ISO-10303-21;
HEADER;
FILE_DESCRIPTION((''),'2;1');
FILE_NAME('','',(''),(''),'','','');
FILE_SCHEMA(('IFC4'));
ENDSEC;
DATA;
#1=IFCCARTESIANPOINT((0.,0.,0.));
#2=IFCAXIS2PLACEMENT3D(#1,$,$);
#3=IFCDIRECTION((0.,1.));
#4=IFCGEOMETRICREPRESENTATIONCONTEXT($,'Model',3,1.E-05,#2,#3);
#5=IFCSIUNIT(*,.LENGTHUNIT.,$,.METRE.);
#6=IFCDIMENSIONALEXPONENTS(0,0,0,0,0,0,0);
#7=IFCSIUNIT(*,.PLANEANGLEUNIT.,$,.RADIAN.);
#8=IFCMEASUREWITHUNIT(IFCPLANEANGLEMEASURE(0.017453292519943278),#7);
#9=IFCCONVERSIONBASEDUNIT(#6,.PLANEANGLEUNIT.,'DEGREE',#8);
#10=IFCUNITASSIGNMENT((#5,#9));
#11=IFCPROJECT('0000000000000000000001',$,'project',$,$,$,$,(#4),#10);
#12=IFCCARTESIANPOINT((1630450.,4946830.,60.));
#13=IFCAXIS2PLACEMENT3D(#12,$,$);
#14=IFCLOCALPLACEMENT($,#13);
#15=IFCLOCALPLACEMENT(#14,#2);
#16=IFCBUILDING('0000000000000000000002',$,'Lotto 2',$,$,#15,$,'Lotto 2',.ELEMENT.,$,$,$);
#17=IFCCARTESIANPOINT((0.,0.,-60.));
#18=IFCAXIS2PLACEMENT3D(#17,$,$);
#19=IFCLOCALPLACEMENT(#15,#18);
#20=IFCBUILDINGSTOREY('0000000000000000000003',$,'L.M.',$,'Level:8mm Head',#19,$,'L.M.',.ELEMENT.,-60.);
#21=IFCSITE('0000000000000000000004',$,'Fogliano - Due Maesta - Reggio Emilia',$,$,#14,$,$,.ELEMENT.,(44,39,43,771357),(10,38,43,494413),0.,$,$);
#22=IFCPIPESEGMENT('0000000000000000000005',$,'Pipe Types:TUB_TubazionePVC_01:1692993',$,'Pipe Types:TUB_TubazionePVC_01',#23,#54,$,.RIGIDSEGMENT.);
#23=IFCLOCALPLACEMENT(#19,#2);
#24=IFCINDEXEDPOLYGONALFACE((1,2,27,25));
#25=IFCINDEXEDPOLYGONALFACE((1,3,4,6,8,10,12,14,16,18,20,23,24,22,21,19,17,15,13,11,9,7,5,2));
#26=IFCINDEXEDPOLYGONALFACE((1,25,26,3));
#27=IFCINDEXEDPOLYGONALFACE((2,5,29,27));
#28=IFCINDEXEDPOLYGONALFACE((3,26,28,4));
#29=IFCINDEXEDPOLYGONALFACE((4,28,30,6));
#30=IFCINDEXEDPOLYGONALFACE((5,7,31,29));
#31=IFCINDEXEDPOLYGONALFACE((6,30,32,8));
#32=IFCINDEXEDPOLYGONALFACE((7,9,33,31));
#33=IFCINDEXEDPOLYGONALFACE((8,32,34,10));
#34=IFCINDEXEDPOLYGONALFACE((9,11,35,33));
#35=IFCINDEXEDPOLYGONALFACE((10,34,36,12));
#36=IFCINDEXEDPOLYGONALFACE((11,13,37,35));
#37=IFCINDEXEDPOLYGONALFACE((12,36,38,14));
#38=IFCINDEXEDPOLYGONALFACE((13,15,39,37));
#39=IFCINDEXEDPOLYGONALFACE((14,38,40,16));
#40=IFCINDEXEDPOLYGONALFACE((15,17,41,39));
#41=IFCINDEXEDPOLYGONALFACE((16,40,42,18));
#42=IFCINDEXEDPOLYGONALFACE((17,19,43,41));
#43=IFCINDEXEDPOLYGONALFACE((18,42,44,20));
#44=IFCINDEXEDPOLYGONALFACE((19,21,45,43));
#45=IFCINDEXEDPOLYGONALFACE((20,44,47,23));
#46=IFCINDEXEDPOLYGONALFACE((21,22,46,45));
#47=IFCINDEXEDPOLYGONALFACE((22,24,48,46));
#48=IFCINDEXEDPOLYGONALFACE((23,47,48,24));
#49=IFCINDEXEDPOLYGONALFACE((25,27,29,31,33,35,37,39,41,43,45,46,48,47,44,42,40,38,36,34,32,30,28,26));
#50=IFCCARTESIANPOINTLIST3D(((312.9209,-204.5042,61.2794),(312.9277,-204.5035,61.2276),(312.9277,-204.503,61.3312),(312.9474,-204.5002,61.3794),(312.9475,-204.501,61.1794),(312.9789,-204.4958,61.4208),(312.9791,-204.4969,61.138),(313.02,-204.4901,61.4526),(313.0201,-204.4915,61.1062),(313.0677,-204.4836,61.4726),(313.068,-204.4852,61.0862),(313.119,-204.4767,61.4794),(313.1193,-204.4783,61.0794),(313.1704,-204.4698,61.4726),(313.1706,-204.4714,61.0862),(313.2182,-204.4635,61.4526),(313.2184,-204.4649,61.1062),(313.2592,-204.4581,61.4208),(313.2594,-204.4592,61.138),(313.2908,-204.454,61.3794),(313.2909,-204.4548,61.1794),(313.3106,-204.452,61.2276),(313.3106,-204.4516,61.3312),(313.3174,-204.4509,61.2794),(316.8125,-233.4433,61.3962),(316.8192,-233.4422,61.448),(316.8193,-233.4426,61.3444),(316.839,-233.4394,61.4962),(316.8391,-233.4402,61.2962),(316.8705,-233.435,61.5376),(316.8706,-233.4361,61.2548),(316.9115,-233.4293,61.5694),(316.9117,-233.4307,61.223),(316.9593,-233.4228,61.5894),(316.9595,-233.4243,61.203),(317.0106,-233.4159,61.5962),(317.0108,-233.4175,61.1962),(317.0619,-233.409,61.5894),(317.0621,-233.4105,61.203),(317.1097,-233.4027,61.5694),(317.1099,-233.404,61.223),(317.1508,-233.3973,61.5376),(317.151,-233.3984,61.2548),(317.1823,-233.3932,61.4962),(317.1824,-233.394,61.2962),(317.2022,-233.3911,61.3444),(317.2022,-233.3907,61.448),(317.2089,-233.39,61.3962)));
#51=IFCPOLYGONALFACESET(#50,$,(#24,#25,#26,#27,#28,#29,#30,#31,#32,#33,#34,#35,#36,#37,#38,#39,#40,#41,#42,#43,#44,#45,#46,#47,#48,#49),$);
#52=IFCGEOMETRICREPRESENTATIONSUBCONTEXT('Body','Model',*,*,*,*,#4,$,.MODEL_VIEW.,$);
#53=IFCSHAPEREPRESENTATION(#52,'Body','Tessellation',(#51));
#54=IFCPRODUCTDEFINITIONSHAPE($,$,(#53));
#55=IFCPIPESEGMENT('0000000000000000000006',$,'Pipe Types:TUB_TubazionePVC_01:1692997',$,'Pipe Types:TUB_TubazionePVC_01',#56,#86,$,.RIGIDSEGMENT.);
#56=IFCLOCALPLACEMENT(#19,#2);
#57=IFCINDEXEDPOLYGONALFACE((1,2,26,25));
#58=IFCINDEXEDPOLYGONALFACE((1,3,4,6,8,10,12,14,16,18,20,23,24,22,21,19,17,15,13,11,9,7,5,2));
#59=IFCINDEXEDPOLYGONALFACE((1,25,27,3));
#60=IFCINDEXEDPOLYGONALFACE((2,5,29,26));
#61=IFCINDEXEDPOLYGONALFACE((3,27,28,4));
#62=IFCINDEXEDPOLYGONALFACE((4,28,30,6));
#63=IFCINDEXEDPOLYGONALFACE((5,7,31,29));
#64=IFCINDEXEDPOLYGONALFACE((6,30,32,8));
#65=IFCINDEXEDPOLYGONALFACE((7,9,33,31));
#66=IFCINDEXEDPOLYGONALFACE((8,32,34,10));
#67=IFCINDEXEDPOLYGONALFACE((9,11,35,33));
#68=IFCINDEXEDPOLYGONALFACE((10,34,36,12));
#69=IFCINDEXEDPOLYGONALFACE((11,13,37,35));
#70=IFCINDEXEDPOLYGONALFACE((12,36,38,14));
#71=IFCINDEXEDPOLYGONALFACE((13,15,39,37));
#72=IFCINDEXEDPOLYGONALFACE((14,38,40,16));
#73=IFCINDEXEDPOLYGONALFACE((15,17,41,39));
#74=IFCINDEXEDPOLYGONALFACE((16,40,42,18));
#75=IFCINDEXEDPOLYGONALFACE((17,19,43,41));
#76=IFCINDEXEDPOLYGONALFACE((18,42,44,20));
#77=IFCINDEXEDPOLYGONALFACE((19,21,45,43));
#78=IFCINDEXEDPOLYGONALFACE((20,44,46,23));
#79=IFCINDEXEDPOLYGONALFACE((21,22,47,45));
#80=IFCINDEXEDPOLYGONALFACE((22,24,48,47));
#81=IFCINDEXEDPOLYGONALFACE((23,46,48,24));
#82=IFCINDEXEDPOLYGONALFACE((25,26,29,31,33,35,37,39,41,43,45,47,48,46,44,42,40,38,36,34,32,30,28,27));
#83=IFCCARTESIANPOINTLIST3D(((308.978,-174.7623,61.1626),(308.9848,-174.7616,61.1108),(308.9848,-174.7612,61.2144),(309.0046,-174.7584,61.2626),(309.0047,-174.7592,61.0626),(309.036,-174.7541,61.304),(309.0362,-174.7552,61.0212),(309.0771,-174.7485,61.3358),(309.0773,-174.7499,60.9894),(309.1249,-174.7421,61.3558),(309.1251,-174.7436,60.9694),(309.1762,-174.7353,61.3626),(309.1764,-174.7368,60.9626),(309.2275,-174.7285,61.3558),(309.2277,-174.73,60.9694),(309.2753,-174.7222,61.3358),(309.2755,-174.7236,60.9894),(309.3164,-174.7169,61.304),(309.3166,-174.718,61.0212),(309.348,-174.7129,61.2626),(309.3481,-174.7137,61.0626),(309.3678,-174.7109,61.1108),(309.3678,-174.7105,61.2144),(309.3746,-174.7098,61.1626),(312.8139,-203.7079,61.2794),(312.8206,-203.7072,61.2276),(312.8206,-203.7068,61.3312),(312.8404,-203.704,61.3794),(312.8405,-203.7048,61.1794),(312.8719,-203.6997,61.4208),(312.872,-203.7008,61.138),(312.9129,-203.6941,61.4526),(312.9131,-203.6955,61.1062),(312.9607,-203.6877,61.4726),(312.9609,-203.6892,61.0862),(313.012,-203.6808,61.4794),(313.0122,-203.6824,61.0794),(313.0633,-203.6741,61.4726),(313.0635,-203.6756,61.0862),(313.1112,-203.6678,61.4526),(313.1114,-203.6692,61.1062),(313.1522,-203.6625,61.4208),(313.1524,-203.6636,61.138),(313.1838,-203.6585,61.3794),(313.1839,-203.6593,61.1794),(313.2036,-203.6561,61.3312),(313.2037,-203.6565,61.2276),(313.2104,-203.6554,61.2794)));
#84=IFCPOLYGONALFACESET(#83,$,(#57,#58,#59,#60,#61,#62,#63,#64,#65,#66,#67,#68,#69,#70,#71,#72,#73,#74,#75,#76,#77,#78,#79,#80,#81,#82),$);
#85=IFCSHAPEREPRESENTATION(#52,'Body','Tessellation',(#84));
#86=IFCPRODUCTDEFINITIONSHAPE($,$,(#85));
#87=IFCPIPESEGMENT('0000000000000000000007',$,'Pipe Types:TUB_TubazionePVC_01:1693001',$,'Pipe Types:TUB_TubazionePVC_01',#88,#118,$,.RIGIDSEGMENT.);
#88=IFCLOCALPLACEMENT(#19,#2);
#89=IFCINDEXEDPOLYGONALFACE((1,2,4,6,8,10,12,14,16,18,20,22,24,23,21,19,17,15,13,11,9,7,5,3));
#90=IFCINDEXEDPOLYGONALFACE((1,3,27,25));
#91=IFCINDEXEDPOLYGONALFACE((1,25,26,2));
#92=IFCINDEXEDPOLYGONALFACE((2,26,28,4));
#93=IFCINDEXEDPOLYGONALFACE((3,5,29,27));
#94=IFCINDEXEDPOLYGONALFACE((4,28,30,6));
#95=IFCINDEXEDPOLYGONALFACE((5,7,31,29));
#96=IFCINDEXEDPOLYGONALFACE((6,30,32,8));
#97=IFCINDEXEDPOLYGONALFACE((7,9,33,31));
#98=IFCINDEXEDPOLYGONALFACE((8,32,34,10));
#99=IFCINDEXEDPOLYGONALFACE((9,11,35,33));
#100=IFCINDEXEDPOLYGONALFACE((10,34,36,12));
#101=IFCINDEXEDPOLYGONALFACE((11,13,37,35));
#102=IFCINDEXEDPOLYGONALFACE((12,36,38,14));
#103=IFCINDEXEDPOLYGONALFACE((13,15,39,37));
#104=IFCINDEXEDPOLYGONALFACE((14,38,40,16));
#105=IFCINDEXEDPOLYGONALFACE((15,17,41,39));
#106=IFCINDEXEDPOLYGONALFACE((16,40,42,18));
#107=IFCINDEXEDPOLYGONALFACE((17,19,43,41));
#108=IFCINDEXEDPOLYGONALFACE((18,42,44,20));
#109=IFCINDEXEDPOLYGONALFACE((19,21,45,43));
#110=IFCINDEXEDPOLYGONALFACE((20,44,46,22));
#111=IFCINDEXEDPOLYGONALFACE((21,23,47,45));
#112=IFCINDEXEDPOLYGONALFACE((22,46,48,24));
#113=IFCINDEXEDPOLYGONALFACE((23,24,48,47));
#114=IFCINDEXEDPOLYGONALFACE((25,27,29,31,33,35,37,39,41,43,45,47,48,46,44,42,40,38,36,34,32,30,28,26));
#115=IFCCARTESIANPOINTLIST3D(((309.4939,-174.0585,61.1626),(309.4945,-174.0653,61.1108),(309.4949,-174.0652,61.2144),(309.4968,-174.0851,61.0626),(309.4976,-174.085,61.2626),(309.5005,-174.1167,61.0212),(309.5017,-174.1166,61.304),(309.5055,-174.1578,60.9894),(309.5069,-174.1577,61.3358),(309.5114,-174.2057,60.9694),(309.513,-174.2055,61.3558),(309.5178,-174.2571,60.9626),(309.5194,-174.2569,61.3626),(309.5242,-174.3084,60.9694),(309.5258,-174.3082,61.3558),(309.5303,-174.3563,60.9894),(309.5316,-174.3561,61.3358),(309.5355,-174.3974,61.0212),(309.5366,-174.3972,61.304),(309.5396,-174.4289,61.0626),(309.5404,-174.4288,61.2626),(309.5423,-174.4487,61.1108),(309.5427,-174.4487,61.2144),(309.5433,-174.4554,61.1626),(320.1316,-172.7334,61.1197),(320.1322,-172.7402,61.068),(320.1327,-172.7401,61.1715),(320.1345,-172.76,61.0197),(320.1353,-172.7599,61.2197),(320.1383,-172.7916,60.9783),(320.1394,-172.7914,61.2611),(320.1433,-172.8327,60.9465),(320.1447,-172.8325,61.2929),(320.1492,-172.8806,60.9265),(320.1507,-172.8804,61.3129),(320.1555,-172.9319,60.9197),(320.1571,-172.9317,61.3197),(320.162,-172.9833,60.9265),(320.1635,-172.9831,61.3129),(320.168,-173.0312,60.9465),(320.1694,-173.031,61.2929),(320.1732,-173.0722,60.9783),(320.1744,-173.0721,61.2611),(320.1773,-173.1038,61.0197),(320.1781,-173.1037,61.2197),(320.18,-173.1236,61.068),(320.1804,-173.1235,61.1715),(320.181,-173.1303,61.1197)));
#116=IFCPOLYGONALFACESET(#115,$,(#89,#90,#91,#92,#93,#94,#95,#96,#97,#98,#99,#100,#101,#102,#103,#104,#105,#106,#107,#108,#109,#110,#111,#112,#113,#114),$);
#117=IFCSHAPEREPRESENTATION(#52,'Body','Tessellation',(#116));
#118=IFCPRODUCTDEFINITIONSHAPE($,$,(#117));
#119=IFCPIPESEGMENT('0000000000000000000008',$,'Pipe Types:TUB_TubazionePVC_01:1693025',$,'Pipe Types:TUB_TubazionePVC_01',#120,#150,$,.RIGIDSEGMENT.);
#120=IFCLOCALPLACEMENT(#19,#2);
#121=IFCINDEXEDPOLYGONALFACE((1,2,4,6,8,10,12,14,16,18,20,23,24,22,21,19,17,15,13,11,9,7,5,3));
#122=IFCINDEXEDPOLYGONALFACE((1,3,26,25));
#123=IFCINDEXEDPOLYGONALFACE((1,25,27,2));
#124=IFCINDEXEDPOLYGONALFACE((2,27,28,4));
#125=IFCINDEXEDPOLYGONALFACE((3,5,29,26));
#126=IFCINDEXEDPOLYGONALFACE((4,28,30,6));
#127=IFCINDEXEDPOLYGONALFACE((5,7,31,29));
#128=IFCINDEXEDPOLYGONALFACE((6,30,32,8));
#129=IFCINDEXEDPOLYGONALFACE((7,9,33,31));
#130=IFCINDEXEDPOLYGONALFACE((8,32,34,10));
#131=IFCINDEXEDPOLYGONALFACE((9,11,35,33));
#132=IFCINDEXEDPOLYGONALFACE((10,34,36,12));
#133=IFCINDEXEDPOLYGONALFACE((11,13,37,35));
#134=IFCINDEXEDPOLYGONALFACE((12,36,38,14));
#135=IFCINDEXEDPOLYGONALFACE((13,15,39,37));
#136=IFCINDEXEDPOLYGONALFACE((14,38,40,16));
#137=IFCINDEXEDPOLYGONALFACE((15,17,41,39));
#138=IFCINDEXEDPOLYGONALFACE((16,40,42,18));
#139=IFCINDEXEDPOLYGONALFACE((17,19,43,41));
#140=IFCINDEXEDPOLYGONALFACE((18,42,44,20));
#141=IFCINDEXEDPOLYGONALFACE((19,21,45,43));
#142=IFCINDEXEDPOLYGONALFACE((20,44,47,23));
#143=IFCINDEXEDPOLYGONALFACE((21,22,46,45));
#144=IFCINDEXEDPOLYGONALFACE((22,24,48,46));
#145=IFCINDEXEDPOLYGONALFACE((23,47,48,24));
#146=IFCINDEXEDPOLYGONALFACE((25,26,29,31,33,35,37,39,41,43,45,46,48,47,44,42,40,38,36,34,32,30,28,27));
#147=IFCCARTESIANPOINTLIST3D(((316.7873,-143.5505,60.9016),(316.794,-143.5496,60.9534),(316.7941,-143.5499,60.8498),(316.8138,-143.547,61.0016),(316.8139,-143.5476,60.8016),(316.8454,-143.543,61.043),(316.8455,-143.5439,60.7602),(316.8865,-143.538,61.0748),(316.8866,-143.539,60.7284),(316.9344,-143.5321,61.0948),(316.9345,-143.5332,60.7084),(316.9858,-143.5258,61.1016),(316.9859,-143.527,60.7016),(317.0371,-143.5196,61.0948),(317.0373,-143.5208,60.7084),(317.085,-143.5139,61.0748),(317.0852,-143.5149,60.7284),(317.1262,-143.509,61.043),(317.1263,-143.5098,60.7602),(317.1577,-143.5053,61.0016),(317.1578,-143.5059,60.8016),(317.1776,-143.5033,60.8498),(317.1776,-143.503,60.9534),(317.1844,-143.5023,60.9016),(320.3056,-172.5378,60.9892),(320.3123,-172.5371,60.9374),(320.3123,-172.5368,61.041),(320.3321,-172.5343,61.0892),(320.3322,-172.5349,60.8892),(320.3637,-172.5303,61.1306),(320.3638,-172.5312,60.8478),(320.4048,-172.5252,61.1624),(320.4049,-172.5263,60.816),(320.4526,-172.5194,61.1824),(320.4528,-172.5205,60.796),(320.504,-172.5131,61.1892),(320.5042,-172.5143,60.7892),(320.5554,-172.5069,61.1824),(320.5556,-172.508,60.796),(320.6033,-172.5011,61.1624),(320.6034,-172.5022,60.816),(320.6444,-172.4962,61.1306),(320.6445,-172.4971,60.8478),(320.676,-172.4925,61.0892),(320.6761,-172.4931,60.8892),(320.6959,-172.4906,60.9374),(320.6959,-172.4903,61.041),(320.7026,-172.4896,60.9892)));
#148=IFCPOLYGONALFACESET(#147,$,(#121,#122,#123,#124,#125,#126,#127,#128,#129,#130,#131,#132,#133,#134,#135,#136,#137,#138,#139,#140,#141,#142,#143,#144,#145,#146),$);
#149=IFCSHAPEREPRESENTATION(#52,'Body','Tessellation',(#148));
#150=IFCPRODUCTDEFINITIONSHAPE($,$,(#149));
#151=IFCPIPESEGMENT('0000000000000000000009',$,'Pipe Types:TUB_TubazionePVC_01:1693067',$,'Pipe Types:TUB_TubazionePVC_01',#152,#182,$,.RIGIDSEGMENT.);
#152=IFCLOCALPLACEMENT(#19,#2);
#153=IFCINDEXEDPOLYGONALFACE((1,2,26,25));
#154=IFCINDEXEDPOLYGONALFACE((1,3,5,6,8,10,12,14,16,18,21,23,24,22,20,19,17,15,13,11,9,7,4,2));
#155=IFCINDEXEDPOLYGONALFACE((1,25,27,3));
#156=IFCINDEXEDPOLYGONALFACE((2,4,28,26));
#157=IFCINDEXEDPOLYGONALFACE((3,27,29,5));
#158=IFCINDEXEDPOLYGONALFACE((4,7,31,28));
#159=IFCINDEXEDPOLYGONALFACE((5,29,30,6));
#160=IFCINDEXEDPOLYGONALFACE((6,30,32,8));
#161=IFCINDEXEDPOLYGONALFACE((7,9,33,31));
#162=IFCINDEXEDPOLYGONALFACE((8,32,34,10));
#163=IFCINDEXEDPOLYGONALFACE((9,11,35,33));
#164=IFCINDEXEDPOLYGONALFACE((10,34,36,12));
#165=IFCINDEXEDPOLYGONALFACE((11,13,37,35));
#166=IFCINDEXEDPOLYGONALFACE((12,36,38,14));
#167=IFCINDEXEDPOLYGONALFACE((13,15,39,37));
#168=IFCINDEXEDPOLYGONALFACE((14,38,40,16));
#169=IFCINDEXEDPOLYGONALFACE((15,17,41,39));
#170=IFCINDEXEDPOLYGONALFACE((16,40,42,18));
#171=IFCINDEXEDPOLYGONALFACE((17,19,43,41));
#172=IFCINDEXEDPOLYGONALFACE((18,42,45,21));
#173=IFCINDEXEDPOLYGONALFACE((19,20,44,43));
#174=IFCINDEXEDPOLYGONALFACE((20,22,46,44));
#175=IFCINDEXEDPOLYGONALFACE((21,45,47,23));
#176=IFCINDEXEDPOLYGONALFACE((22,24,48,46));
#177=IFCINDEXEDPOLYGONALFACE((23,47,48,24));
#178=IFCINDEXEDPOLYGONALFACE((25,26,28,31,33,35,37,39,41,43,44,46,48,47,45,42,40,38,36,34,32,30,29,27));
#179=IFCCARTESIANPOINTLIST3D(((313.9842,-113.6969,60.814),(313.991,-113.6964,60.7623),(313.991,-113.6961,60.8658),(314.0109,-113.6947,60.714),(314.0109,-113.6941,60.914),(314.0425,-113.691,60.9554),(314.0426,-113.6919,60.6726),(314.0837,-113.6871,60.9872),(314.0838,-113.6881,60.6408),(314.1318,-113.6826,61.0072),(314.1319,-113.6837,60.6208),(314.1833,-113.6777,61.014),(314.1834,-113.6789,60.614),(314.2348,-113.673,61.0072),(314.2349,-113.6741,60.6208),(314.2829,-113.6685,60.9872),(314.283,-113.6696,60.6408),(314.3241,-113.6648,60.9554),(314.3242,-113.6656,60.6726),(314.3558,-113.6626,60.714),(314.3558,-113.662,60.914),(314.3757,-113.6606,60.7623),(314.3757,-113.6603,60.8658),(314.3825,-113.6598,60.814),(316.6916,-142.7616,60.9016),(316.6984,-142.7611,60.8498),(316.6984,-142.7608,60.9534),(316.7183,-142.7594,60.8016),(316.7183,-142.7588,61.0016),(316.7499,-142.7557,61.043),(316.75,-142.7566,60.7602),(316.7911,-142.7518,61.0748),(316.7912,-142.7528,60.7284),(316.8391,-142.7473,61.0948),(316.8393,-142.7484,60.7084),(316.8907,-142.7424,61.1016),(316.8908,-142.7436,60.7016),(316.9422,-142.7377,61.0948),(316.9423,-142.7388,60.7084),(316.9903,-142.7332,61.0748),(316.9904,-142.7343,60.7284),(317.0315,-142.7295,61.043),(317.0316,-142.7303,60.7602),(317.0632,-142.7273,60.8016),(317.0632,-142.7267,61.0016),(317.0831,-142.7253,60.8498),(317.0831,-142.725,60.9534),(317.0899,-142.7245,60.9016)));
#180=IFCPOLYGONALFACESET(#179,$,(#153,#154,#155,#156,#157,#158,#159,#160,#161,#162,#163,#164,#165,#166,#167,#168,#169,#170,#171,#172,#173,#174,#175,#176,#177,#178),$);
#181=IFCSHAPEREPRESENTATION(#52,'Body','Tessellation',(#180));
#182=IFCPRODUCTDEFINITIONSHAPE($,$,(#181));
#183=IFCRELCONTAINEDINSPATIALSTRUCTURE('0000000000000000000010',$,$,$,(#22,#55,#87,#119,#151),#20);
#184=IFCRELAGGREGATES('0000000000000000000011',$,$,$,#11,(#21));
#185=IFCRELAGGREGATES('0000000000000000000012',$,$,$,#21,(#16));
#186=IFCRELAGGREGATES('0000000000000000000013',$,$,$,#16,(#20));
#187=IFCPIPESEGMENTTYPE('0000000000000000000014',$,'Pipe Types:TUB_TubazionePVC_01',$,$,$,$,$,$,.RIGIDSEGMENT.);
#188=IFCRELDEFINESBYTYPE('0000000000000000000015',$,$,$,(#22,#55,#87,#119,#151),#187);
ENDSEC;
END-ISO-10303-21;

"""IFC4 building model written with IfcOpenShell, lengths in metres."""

from ifc_helpers import new_model, entity, si_unit, converted_unit, direction, frame, origin, place, context, subcontext, project, spatial, arc, indexed_curve, outline, extrude, type_object, element, save


model = new_model("IFC4")

# Units and contexts
model_context = context("Model", 3, precision=1e-05, world=origin(), true_north=direction((0.0, 1.0)))
body_context = subcontext(model_context, "Body", "Model", "MODEL_VIEW")
ifc_project = project(units=[si_unit("LENGTHUNIT", "METRE"), converted_unit("PLANEANGLEUNIT", "DEGREE", entity("IfcPlaneAngleMeasure", 0.017453292519943278), si_unit("PLANEANGLEUNIT", "RADIAN"), dimensions=[0, 0, 0, 0, 0, 0, 0])], contexts=[model_context])

# Site, building, storey
site_placement = place(None, frame((1630450.0, 4946830.0, 60.0)))
site = spatial("IfcSite", under=ifc_project, at=site_placement, Name="Fogliano - Due Maesta - Reggio Emilia", CompositionType="ELEMENT", RefLatitude=(44, 39, 43, 771357), RefLongitude=(10, 38, 43, 494413), RefElevation=0.0)
building_placement = place(site_placement, origin())
building = spatial("IfcBuilding", under=site, at=building_placement, Name="Lotto 2", LongName="Lotto 2", CompositionType="ELEMENT")
storey_placement = place(building_placement, frame((0.0, 0.0, -60.0)))
storey = spatial("IfcBuildingStorey", under=building, at=storey_placement, Name="L.M.", ObjectType="Level:8mm Head", LongName="L.M.", CompositionType="ELEMENT", Elevation=-60.0)

# Pipe segments
pipe_segment_type = type_object("IfcPipeSegmentType", Name="Pipe Types:TUB_TubazionePVC_01", PredefinedType="RIGIDSEGMENT")
pipe_segment_1_placement = place(storey_placement, origin())
element("IfcPipeSegment", 1, at=pipe_segment_1_placement, inside=storey, type_object=pipe_segment_type, Name="Pipe Types:TUB_TubazionePVC_01:1692993", ObjectType="Pipe Types:TUB_TubazionePVC_01", PredefinedType="RIGIDSEGMENT", context=body_context, shape_type="SweptSolid", body=[
    extrude(outline(indexed_curve([(0.2, 0.0), (0.1414, 0.1414), (0.0, 0.2), (-0.1414, 0.1414), (-0.2, 0.0), (-0.1414, -0.1414), (0.0, -0.2), (0.1414, -0.1414)], segments=[arc(1, 2, 3), arc(3, 4, 5), arc(5, 6, 7), arc(7, 8, 1)], self_intersect=False)), frame((317.0107, -233.4167, 61.3962), z_axis=(-0.133273, 0.991071, -0.004), x_axis=(0.991079, 0.133275, 0.0)), (0.0, 0.0, 1.0), 29.1999),
])
pipe_segment_2_placement = place(storey_placement, origin())
element("IfcPipeSegment", 2, at=pipe_segment_2_placement, inside=storey, type_object=pipe_segment_type, Name="Pipe Types:TUB_TubazionePVC_01:1692997", ObjectType="Pipe Types:TUB_TubazionePVC_01", PredefinedType="RIGIDSEGMENT", context=body_context, shape_type="SweptSolid", body=[
    extrude(outline(indexed_curve([(0.2, 0.0), (0.1414, 0.1414), (0.0, 0.2), (-0.1414, 0.1414), (-0.2, 0.0), (-0.1414, -0.1414), (0.0, -0.2), (0.1414, -0.1414)], segments=[arc(1, 2, 3), arc(3, 4, 5), arc(5, 6, 7), arc(7, 8, 1)], self_intersect=False)), frame((309.1763, -174.736, 61.1626), z_axis=(0.131369, -0.991326, 0.004), x_axis=(0.991333, 0.13137, 0.0)), (0.0, 0.0, 1.0), 29.1989),
])
pipe_segment_3_placement = place(storey_placement, origin())
element("IfcPipeSegment", 3, at=pipe_segment_3_placement, inside=storey, type_object=pipe_segment_type, Name="Pipe Types:TUB_TubazionePVC_01:1693001", ObjectType="Pipe Types:TUB_TubazionePVC_01", PredefinedType="RIGIDSEGMENT", context=body_context, shape_type="SweptSolid", body=[
    extrude(outline(indexed_curve([(0.2, 0.0), (0.1414, 0.1414), (0.0, 0.2), (-0.1414, 0.1414), (-0.2, 0.0), (-0.1414, -0.1414), (0.0, -0.2), (0.1414, -0.1414)], segments=[arc(1, 2, 3), arc(3, 4, 5), arc(5, 6, 7), arc(7, 8, 1)], self_intersect=False)), frame((320.1563, -172.9318, 61.1197), z_axis=(-0.992322, -0.123613, 0.004), x_axis=(0.123614, -0.99233, 0.0)), (0.0, 0.0, 1.0), 10.72),
])
pipe_segment_4_placement = place(storey_placement, origin())
element("IfcPipeSegment", 4, at=pipe_segment_4_placement, inside=storey, type_object=pipe_segment_type, Name="Pipe Types:TUB_TubazionePVC_01:1693025", ObjectType="Pipe Types:TUB_TubazionePVC_01", PredefinedType="RIGIDSEGMENT", context=body_context, shape_type="SweptSolid", body=[
    extrude(outline(indexed_curve([(0.2, 0.0), (0.1414, 0.1414), (0.0, 0.2), (-0.1414, 0.1414), (-0.2, 0.0), (-0.1414, -0.1414), (0.0, -0.2), (0.1414, -0.1414)], segments=[arc(1, 2, 3), arc(3, 4, 5), arc(5, 6, 7), arc(7, 8, 1)], self_intersect=False)), frame((316.9858, -143.5264, 60.9016), z_axis=(0.120488, -0.99271, 0.003), x_axis=(0.992715, 0.120489, 0.0)), (0.0, 0.0, 1.0), 29.2001),
])
pipe_segment_5_placement = place(storey_placement, origin())
element("IfcPipeSegment", 5, at=pipe_segment_5_placement, inside=storey, type_object=pipe_segment_type, Name="Pipe Types:TUB_TubazionePVC_01:1693067", ObjectType="Pipe Types:TUB_TubazionePVC_01", PredefinedType="RIGIDSEGMENT", context=body_context, shape_type="SweptSolid", body=[
    extrude(outline(indexed_curve([(0.2, 0.0), (0.1414, 0.1414), (0.0, 0.2), (-0.1414, 0.1414), (-0.2, 0.0), (-0.1414, -0.1414), (0.0, -0.2), (0.1414, -0.1414)], segments=[arc(1, 2, 3), arc(3, 4, 5), arc(5, 6, 7), arc(7, 8, 1)], self_intersect=False)), frame((314.1834, -113.6783, 60.814), z_axis=(0.092749, -0.995685, 0.003), x_axis=(0.99569, 0.092749, 0.0)), (0.0, 0.0, 1.0), 29.1907),
])

save(model, "model.ifc")
